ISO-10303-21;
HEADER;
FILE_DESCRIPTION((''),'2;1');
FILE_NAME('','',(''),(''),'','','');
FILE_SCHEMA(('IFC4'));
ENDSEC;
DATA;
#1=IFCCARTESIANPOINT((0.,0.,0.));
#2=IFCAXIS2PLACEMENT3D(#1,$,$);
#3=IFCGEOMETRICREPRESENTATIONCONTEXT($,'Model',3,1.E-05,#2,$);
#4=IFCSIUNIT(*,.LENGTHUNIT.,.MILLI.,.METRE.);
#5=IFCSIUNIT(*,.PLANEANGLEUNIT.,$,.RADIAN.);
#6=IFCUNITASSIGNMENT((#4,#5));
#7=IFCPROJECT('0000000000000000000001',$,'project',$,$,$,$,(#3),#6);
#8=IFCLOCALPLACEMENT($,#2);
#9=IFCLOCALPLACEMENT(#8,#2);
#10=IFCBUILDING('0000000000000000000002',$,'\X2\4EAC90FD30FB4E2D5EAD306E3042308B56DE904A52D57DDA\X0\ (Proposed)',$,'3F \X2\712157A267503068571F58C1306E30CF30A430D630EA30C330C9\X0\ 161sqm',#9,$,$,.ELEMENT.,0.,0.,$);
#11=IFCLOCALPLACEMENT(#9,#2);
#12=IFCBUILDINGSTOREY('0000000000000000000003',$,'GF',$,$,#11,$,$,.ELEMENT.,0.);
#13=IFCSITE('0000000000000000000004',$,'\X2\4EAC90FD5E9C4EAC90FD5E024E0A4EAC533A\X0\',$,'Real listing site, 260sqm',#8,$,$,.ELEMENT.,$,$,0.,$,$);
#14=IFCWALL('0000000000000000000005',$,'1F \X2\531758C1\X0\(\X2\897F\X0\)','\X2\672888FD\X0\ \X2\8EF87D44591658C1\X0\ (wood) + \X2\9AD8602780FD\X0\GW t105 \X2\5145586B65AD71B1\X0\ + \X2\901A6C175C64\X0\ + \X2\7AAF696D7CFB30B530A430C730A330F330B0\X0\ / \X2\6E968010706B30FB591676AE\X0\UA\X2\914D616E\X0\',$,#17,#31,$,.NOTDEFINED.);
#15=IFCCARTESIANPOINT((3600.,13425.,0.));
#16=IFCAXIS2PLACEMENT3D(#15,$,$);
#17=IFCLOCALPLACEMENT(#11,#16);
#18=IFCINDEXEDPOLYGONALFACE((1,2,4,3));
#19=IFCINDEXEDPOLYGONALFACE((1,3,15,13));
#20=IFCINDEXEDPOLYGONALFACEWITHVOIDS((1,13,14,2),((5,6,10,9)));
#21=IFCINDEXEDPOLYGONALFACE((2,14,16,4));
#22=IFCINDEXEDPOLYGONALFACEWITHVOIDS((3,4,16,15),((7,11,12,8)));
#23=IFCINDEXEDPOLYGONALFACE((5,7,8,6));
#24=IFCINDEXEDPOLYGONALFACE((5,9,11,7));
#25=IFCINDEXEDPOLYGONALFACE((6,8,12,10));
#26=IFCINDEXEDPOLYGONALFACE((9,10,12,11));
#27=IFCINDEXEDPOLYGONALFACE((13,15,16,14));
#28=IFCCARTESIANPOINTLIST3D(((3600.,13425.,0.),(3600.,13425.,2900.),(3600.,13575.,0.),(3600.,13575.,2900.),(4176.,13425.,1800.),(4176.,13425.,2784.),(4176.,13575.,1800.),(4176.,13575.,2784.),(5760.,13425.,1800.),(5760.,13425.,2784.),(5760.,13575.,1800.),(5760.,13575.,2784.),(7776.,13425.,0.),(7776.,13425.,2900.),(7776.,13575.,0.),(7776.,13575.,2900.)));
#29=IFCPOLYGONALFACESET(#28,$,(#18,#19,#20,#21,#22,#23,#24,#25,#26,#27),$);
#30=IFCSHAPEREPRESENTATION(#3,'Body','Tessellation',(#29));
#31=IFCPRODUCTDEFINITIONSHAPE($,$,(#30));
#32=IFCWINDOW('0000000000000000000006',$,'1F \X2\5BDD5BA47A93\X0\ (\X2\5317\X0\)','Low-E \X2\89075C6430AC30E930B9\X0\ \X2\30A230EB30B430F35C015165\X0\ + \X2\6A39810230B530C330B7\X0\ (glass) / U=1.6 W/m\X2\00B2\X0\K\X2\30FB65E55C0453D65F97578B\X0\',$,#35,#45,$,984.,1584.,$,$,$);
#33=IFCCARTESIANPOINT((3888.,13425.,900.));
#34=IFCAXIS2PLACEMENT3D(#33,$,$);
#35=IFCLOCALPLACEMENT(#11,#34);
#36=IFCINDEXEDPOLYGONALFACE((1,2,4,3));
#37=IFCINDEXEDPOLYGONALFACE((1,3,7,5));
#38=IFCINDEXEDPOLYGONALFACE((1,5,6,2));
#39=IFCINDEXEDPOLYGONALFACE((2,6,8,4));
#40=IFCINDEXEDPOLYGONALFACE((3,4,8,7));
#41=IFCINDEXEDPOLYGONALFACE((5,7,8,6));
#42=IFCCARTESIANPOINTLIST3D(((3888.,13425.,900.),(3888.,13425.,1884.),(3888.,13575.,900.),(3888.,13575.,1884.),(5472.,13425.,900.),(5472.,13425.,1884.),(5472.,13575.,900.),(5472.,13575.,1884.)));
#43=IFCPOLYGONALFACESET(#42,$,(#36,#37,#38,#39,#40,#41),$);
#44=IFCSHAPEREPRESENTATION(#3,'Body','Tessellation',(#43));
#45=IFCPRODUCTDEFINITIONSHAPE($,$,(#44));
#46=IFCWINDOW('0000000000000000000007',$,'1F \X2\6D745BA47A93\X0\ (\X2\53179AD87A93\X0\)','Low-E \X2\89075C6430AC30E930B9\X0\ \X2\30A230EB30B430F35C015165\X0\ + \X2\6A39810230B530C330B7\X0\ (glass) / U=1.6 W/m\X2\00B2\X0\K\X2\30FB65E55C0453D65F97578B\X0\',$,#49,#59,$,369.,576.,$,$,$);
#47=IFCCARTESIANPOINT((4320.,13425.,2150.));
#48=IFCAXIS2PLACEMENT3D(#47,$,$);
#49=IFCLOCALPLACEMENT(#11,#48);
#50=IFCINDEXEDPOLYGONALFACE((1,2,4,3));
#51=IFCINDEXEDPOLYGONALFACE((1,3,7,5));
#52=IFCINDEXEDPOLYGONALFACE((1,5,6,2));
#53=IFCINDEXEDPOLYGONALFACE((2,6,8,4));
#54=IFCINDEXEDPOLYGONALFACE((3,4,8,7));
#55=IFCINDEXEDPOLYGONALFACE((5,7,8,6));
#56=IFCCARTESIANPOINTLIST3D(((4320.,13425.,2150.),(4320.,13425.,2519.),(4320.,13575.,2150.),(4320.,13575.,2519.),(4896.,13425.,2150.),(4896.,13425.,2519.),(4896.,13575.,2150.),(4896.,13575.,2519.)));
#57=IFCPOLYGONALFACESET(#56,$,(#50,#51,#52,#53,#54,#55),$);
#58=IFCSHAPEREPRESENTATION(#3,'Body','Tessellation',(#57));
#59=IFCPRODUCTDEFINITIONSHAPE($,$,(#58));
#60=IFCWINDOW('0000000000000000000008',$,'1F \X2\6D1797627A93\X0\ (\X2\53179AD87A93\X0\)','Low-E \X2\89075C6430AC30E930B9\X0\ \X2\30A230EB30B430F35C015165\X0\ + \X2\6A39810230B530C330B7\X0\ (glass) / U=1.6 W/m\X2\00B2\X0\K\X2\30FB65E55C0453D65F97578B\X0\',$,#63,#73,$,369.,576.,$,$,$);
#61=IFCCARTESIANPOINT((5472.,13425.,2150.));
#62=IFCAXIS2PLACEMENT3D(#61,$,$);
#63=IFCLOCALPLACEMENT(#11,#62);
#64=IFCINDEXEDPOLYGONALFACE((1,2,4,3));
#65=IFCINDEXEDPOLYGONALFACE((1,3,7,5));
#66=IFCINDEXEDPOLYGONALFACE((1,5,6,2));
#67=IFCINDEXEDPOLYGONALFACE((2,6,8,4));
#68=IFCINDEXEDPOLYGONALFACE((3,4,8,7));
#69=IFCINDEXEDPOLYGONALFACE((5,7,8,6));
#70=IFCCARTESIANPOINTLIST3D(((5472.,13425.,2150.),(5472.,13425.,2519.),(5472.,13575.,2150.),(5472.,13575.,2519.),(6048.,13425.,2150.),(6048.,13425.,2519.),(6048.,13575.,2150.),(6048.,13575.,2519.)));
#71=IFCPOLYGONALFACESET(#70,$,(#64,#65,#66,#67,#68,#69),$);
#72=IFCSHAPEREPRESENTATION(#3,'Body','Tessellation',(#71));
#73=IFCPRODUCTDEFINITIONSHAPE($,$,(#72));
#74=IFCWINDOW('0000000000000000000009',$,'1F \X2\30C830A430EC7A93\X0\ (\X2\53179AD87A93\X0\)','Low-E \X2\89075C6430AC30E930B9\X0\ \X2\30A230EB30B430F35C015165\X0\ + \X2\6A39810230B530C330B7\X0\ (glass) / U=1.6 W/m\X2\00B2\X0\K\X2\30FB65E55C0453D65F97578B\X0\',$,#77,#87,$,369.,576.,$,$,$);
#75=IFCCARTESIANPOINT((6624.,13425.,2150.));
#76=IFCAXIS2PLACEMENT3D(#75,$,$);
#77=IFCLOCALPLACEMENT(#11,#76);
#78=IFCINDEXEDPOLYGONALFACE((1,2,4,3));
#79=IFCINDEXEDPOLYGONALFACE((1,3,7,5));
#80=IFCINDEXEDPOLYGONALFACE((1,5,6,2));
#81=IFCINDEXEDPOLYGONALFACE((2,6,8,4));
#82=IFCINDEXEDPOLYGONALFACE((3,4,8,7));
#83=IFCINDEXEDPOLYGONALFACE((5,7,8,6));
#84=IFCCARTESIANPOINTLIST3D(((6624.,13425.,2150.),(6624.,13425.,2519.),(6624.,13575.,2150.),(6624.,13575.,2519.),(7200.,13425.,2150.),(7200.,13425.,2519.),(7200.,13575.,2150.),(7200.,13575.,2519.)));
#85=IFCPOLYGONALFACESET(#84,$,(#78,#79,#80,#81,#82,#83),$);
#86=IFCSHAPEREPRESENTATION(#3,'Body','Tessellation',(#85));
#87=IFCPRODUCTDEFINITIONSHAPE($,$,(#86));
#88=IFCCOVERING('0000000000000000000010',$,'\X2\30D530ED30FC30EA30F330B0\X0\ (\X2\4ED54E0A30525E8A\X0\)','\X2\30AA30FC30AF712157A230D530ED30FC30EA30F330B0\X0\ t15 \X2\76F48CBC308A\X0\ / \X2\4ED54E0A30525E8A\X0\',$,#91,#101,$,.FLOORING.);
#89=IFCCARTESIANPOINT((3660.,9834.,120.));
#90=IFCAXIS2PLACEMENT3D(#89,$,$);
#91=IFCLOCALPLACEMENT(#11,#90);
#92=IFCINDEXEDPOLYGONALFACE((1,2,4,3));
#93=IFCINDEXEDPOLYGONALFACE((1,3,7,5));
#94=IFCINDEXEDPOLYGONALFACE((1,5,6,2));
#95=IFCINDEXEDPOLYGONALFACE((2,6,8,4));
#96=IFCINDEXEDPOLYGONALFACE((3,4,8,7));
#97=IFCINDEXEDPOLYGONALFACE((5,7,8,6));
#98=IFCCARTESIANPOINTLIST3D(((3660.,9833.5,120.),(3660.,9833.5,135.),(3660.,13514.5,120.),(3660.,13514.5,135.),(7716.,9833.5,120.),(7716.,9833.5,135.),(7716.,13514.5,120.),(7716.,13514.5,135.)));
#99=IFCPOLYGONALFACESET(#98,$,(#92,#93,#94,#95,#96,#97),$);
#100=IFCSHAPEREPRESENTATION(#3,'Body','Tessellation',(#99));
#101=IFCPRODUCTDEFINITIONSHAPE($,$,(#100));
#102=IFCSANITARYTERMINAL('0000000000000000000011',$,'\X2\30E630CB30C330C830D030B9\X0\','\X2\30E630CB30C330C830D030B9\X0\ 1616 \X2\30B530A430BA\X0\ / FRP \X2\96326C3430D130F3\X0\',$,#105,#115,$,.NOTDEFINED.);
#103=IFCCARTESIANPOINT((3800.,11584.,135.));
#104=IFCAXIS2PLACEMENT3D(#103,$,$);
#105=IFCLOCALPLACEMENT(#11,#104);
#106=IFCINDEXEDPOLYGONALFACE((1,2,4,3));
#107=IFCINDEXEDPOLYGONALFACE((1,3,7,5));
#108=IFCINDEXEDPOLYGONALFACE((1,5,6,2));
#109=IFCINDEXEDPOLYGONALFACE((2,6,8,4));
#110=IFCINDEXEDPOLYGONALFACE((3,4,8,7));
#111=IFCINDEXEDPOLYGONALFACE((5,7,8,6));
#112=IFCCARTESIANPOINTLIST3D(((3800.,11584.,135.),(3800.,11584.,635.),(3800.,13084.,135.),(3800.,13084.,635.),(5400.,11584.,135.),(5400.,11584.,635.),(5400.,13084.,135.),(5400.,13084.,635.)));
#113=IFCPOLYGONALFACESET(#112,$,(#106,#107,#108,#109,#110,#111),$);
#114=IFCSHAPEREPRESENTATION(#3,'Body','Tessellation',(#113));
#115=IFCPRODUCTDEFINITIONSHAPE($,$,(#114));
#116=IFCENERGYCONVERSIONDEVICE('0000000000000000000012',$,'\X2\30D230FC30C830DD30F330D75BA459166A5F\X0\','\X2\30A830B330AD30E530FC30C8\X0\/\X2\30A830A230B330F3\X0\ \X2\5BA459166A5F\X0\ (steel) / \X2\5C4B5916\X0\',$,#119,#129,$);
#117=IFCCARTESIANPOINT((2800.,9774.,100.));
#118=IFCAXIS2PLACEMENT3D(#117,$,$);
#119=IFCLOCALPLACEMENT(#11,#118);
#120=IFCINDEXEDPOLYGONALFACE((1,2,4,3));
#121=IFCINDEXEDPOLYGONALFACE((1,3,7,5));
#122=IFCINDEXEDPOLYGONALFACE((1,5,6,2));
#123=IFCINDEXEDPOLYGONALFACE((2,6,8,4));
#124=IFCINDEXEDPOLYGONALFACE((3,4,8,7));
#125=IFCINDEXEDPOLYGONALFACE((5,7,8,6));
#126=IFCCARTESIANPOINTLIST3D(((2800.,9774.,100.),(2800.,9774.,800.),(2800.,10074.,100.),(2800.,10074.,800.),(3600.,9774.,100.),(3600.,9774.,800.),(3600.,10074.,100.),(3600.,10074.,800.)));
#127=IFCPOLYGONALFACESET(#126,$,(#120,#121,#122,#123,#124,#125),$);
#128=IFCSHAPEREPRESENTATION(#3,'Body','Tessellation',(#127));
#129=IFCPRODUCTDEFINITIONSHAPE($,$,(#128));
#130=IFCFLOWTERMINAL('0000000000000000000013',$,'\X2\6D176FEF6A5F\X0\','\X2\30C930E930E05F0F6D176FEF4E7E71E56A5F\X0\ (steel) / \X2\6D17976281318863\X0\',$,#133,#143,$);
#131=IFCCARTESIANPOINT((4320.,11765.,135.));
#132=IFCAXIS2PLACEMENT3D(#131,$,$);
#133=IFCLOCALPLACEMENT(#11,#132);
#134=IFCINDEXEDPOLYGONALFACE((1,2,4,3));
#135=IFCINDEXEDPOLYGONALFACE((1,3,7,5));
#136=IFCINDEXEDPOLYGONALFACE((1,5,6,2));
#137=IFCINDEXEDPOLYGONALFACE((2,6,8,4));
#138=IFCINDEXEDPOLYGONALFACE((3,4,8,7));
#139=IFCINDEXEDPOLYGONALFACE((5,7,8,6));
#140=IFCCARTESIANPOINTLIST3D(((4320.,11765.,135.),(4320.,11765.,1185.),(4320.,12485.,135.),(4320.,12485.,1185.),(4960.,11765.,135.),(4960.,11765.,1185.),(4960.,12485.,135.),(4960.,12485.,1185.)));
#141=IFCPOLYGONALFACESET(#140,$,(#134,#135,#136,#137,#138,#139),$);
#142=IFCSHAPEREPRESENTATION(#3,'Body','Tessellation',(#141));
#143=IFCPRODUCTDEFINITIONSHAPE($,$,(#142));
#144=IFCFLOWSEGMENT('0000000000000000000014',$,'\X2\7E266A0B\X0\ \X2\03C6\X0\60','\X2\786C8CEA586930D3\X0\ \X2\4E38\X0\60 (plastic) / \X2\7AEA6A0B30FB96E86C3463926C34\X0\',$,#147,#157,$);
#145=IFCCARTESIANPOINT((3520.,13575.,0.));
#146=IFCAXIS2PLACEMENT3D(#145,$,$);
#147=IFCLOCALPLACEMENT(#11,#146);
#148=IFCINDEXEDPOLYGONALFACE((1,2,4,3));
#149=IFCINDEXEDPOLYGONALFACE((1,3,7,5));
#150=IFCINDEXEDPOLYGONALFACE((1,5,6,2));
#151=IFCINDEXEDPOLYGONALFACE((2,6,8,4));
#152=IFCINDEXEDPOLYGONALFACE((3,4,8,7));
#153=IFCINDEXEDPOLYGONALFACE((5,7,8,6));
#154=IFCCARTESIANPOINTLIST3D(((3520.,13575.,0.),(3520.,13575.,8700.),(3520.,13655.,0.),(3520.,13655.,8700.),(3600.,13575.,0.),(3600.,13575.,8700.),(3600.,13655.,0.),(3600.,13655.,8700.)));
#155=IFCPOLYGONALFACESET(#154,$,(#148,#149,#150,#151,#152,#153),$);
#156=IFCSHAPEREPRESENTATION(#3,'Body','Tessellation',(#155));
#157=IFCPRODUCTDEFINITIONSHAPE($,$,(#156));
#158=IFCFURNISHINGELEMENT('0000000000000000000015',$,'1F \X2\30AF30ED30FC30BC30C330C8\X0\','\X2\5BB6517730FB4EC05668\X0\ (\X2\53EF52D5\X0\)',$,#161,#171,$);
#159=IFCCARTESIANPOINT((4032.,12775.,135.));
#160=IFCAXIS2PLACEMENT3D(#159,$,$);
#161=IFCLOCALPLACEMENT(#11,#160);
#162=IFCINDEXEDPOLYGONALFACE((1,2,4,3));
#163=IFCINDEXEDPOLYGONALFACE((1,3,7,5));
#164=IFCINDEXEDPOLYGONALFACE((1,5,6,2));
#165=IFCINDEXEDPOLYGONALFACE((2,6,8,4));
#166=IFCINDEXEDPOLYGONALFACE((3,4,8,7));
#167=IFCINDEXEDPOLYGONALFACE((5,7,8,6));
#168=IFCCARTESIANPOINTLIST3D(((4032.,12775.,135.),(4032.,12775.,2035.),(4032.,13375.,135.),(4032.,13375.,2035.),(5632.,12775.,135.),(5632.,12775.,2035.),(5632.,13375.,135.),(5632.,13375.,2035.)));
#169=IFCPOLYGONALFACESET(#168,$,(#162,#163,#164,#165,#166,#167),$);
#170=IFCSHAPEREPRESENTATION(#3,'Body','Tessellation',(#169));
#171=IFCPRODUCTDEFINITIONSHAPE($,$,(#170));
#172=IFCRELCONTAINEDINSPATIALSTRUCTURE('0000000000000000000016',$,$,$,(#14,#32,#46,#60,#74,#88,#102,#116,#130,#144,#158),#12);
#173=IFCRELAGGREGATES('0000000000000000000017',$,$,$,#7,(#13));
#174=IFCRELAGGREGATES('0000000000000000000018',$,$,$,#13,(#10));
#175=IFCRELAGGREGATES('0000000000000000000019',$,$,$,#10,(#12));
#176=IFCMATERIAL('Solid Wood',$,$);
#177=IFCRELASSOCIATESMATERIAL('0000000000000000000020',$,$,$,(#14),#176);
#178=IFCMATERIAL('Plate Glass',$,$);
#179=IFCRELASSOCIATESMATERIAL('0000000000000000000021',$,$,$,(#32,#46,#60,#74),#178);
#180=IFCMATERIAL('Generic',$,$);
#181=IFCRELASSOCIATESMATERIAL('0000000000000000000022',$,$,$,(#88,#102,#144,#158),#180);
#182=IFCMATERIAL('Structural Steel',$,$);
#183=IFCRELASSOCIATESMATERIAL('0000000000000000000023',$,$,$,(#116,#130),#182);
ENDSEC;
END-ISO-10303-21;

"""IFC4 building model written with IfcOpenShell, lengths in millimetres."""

from ifc_helpers import new_model, si_unit, frame, frame_2d, origin, place, context, project, spatial, rectangle, extrude, material, element, fill, save


model = new_model("IFC4")

# Units and contexts
model_context = context("Model", 3, precision=1e-05, world=origin())
ifc_project = project(units=[si_unit("LENGTHUNIT", "METRE", prefix="MILLI"), si_unit("PLANEANGLEUNIT", "RADIAN")], contexts=[model_context])

# Site, building, storey
site_placement = place(None, origin())
site = spatial("IfcSite", under=ifc_project, at=site_placement, Name="京都府京都市上京区", ObjectType="Real listing site, 260sqm", CompositionType="ELEMENT", RefElevation=0.0)
building_placement = place(site_placement, origin())
building = spatial("IfcBuilding", under=site, at=building_placement, Name="京都・中庭のある回遊動線 (Proposed)", ObjectType="3F 無垢材と土壁のハイブリッド 161sqm", CompositionType="ELEMENT", ElevationOfRefHeight=0.0, ElevationOfTerrain=0.0)
storey_placement = place(building_placement, origin())
storey = spatial("IfcBuildingStorey", under=building, at=storey_placement, Name="GF", CompositionType="ELEMENT", Elevation=0.0)

# Shared definitions
ifc_material_1 = material(Name="Solid Wood")

# Wall, openings, windows
wall_1_placement = place(storey_placement, frame((3600.0, 13425.0, 0.0)))
wall_1 = element("IfcWall", 1, at=wall_1_placement, inside=storey, material=ifc_material_1, Name="1F 北壁(西)", Description="木製 軸組外壁 (wood) + 高性能GW t105 充填断熱 + 通気層 + 窯業系サイディング / 準耐火・外皮UA配慮", PredefinedType="NOTDEFINED", context=model_context, shape_type="SweptSolid", body=[
    extrude(rectangle(XDim=4176.0, YDim=150.0, at=frame_2d((2088.0, 75.0))), frame((3600.0, 13425.0, 0.0)), (0.0, 0.0, 1.0), 2900.0),
])
opening_1_placement = place(storey_placement, frame((3888.0, 13425.0, 900.0)))
opening_1 = element("IfcOpeningElement", 2, at=opening_1_placement, cuts=wall_1, PredefinedType="NOTDEFINED", context=model_context, shape_type="SweptSolid", body=[
    extrude(rectangle(XDim=1584.0, YDim=150.0, at=frame_2d((792.0, 75.0))), frame((3888.0, 13425.0, 900.0)), (0.0, 0.0, 1.0), 984.0),
])
opening_2_placement = place(storey_placement, frame((4320.0, 13425.0, 2150.0)))
opening_2 = element("IfcOpeningElement", 3, at=opening_2_placement, cuts=wall_1, PredefinedType="NOTDEFINED", context=model_context, shape_type="SweptSolid", body=[
    extrude(rectangle(XDim=576.0, YDim=150.0, at=frame_2d((288.0, 75.0))), frame((4320.0, 13425.0, 2150.0)), (0.0, 0.0, 1.0), 369.0),
])
opening_3_placement = place(storey_placement, frame((5472.0, 13425.0, 2150.0)))
opening_3 = element("IfcOpeningElement", 4, at=opening_3_placement, cuts=wall_1, PredefinedType="NOTDEFINED", context=model_context, shape_type="SweptSolid", body=[
    extrude(rectangle(XDim=576.0, YDim=150.0, at=frame_2d((288.0, 75.0))), frame((5472.0, 13425.0, 2150.0)), (0.0, 0.0, 1.0), 369.0),
])
opening_4_placement = place(storey_placement, frame((6624.0, 13425.0, 2150.0)))
opening_4 = element("IfcOpeningElement", 5, at=opening_4_placement, cuts=wall_1, PredefinedType="NOTDEFINED", context=model_context, shape_type="SweptSolid", body=[
    extrude(rectangle(XDim=576.0, YDim=150.0, at=frame_2d((288.0, 75.0))), frame((6624.0, 13425.0, 2150.0)), (0.0, 0.0, 1.0), 369.0),
])
ifc_material_2 = material(Name="Plate Glass")
window_1_placement = place(storey_placement, frame((3888.0, 13425.0, 900.0)))
window_1 = element("IfcWindow", 6, at=window_1_placement, inside=storey, material=ifc_material_2, Name="1F 寝室窓 (北)", Description="Low-E 複層ガラス アルゴン封入 + 樹脂サッシ (glass) / U=1.6 W/m²K・日射取得型", OverallHeight=984.0, OverallWidth=1584.0, context=model_context, shape_type="SweptSolid", body=[
    extrude(rectangle(XDim=1584.0, YDim=150.0, at=frame_2d((792.0, 75.0))), frame((3888.0, 13425.0, 900.0)), (0.0, 0.0, 1.0), 984.0),
])
fill(opening_1, window_1)
window_2_placement = place(storey_placement, frame((4320.0, 13425.0, 2150.0)))
window_2 = element("IfcWindow", 7, at=window_2_placement, inside=storey, material=ifc_material_2, Name="1F 浴室窓 (北高窓)", Description="Low-E 複層ガラス アルゴン封入 + 樹脂サッシ (glass) / U=1.6 W/m²K・日射取得型", OverallHeight=369.0, OverallWidth=576.0, context=model_context, shape_type="SweptSolid", body=[
    extrude(rectangle(XDim=576.0, YDim=150.0, at=frame_2d((288.0, 75.0))), frame((4320.0, 13425.0, 2150.0)), (0.0, 0.0, 1.0), 369.0),
])
fill(opening_2, window_2)
window_3_placement = place(storey_placement, frame((5472.0, 13425.0, 2150.0)))
window_3 = element("IfcWindow", 8, at=window_3_placement, inside=storey, material=ifc_material_2, Name="1F 洗面窓 (北高窓)", Description="Low-E 複層ガラス アルゴン封入 + 樹脂サッシ (glass) / U=1.6 W/m²K・日射取得型", OverallHeight=369.0, OverallWidth=576.0, context=model_context, shape_type="SweptSolid", body=[
    extrude(rectangle(XDim=576.0, YDim=150.0, at=frame_2d((288.0, 75.0))), frame((5472.0, 13425.0, 2150.0)), (0.0, 0.0, 1.0), 369.0),
])
fill(opening_3, window_3)
window_4_placement = place(storey_placement, frame((6624.0, 13425.0, 2150.0)))
window_4 = element("IfcWindow", 9, at=window_4_placement, inside=storey, material=ifc_material_2, Name="1F トイレ窓 (北高窓)", Description="Low-E 複層ガラス アルゴン封入 + 樹脂サッシ (glass) / U=1.6 W/m²K・日射取得型", OverallHeight=369.0, OverallWidth=576.0, context=model_context, shape_type="SweptSolid", body=[
    extrude(rectangle(XDim=576.0, YDim=150.0, at=frame_2d((288.0, 75.0))), frame((6624.0, 13425.0, 2150.0)), (0.0, 0.0, 1.0), 369.0),
])
fill(opening_4, window_4)

# Covering
ifc_material_3 = material(Name="Generic")
covering_placement = place(storey_placement, frame((3660.0, 9834.0, 120.0)))
element("IfcCovering", 10, at=covering_placement, inside=storey, material=ifc_material_3, Name="フローリング (仕上げ床)", Description="オーク無垢フローリング t15 直貼り / 仕上げ床", PredefinedType="FLOORING", context=model_context, shape_type="SweptSolid", body=[
    extrude(rectangle(XDim=4056.0, YDim=3681.0, at=frame_2d((2028.0, 1840.0))), frame((3660.0, 9834.0, 120.0)), (0.0, 0.0, 1.0), 15.0),
])

# Sanitary terminal
sanitary_terminal_placement = place(storey_placement, frame((3800.0, 11584.0, 135.0)))
element("IfcSanitaryTerminal", 11, at=sanitary_terminal_placement, inside=storey, material=ifc_material_3, Name="ユニットバス", Description="ユニットバス 1616 サイズ / FRP 防水パン", PredefinedType="NOTDEFINED", context=model_context, shape_type="SweptSolid", body=[
    extrude(rectangle(XDim=1600.0, YDim=1500.0, at=frame_2d((800.0, 750.0))), frame((3800.0, 11584.0, 135.0)), (0.0, 0.0, 1.0), 500.0),
])

# Energy conversion device
ifc_material_4 = material(Name="Structural Steel")
energy_conversion_device_placement = place(storey_placement, frame((2800.0, 9774.0, 100.0)))
element("IfcEnergyConversionDevice", 12, at=energy_conversion_device_placement, inside=storey, material=ifc_material_4, Name="ヒートポンプ室外機", Description="エコキュート/エアコン 室外機 (steel) / 屋外", context=model_context, shape_type="SweptSolid", body=[
    extrude(rectangle(XDim=800.0, YDim=300.0, at=frame_2d((400.0, 150.0))), frame((2800.0, 9774.0, 100.0)), (0.0, 0.0, 1.0), 700.0),
])

# Flow terminal
flow_terminal_placement = place(storey_placement, frame((4320.0, 11765.0, 135.0)))
element("IfcFlowTerminal", 13, at=flow_terminal_placement, inside=storey, material=ifc_material_4, Name="洗濯機", Description="ドラム式洗濯乾燥機 (steel) / 洗面脱衣", context=model_context, shape_type="SweptSolid", body=[
    extrude(rectangle(XDim=640.0, YDim=720.0, at=frame_2d((320.0, 360.0))), frame((4320.0, 11765.0, 135.0)), (0.0, 0.0, 1.0), 1050.0),
])

# Flow segment
flow_segment_placement = place(storey_placement, frame((3520.0, 13575.0, 0.0)))
element("IfcFlowSegment", 14, at=flow_segment_placement, inside=storey, material=ifc_material_3, Name="縦樋 φ60", Description="硬質塩ビ 丸60 (plastic) / 竪樋・雨水排水", context=model_context, shape_type="SweptSolid", body=[
    extrude(rectangle(XDim=80.0, YDim=80.0, at=frame_2d((40.0, 40.0))), frame((3520.0, 13575.0, 0.0)), (0.0, 0.0, 1.0), 8700.0),
])

# Furnishing element
furnishing_placement = place(storey_placement, frame((4032.0, 12775.0, 135.0)))
element("IfcFurnishingElement", 15, at=furnishing_placement, inside=storey, material=ifc_material_3, Name="1F クローゼット", Description="家具・什器 (可動)", context=model_context, shape_type="SweptSolid", body=[
    extrude(rectangle(XDim=1600.0, YDim=600.0, at=frame_2d((800.0, 300.0))), frame((4032.0, 12775.0, 135.0)), (0.0, 0.0, 1.0), 1900.0),
])

save(model, "model.ifc")
